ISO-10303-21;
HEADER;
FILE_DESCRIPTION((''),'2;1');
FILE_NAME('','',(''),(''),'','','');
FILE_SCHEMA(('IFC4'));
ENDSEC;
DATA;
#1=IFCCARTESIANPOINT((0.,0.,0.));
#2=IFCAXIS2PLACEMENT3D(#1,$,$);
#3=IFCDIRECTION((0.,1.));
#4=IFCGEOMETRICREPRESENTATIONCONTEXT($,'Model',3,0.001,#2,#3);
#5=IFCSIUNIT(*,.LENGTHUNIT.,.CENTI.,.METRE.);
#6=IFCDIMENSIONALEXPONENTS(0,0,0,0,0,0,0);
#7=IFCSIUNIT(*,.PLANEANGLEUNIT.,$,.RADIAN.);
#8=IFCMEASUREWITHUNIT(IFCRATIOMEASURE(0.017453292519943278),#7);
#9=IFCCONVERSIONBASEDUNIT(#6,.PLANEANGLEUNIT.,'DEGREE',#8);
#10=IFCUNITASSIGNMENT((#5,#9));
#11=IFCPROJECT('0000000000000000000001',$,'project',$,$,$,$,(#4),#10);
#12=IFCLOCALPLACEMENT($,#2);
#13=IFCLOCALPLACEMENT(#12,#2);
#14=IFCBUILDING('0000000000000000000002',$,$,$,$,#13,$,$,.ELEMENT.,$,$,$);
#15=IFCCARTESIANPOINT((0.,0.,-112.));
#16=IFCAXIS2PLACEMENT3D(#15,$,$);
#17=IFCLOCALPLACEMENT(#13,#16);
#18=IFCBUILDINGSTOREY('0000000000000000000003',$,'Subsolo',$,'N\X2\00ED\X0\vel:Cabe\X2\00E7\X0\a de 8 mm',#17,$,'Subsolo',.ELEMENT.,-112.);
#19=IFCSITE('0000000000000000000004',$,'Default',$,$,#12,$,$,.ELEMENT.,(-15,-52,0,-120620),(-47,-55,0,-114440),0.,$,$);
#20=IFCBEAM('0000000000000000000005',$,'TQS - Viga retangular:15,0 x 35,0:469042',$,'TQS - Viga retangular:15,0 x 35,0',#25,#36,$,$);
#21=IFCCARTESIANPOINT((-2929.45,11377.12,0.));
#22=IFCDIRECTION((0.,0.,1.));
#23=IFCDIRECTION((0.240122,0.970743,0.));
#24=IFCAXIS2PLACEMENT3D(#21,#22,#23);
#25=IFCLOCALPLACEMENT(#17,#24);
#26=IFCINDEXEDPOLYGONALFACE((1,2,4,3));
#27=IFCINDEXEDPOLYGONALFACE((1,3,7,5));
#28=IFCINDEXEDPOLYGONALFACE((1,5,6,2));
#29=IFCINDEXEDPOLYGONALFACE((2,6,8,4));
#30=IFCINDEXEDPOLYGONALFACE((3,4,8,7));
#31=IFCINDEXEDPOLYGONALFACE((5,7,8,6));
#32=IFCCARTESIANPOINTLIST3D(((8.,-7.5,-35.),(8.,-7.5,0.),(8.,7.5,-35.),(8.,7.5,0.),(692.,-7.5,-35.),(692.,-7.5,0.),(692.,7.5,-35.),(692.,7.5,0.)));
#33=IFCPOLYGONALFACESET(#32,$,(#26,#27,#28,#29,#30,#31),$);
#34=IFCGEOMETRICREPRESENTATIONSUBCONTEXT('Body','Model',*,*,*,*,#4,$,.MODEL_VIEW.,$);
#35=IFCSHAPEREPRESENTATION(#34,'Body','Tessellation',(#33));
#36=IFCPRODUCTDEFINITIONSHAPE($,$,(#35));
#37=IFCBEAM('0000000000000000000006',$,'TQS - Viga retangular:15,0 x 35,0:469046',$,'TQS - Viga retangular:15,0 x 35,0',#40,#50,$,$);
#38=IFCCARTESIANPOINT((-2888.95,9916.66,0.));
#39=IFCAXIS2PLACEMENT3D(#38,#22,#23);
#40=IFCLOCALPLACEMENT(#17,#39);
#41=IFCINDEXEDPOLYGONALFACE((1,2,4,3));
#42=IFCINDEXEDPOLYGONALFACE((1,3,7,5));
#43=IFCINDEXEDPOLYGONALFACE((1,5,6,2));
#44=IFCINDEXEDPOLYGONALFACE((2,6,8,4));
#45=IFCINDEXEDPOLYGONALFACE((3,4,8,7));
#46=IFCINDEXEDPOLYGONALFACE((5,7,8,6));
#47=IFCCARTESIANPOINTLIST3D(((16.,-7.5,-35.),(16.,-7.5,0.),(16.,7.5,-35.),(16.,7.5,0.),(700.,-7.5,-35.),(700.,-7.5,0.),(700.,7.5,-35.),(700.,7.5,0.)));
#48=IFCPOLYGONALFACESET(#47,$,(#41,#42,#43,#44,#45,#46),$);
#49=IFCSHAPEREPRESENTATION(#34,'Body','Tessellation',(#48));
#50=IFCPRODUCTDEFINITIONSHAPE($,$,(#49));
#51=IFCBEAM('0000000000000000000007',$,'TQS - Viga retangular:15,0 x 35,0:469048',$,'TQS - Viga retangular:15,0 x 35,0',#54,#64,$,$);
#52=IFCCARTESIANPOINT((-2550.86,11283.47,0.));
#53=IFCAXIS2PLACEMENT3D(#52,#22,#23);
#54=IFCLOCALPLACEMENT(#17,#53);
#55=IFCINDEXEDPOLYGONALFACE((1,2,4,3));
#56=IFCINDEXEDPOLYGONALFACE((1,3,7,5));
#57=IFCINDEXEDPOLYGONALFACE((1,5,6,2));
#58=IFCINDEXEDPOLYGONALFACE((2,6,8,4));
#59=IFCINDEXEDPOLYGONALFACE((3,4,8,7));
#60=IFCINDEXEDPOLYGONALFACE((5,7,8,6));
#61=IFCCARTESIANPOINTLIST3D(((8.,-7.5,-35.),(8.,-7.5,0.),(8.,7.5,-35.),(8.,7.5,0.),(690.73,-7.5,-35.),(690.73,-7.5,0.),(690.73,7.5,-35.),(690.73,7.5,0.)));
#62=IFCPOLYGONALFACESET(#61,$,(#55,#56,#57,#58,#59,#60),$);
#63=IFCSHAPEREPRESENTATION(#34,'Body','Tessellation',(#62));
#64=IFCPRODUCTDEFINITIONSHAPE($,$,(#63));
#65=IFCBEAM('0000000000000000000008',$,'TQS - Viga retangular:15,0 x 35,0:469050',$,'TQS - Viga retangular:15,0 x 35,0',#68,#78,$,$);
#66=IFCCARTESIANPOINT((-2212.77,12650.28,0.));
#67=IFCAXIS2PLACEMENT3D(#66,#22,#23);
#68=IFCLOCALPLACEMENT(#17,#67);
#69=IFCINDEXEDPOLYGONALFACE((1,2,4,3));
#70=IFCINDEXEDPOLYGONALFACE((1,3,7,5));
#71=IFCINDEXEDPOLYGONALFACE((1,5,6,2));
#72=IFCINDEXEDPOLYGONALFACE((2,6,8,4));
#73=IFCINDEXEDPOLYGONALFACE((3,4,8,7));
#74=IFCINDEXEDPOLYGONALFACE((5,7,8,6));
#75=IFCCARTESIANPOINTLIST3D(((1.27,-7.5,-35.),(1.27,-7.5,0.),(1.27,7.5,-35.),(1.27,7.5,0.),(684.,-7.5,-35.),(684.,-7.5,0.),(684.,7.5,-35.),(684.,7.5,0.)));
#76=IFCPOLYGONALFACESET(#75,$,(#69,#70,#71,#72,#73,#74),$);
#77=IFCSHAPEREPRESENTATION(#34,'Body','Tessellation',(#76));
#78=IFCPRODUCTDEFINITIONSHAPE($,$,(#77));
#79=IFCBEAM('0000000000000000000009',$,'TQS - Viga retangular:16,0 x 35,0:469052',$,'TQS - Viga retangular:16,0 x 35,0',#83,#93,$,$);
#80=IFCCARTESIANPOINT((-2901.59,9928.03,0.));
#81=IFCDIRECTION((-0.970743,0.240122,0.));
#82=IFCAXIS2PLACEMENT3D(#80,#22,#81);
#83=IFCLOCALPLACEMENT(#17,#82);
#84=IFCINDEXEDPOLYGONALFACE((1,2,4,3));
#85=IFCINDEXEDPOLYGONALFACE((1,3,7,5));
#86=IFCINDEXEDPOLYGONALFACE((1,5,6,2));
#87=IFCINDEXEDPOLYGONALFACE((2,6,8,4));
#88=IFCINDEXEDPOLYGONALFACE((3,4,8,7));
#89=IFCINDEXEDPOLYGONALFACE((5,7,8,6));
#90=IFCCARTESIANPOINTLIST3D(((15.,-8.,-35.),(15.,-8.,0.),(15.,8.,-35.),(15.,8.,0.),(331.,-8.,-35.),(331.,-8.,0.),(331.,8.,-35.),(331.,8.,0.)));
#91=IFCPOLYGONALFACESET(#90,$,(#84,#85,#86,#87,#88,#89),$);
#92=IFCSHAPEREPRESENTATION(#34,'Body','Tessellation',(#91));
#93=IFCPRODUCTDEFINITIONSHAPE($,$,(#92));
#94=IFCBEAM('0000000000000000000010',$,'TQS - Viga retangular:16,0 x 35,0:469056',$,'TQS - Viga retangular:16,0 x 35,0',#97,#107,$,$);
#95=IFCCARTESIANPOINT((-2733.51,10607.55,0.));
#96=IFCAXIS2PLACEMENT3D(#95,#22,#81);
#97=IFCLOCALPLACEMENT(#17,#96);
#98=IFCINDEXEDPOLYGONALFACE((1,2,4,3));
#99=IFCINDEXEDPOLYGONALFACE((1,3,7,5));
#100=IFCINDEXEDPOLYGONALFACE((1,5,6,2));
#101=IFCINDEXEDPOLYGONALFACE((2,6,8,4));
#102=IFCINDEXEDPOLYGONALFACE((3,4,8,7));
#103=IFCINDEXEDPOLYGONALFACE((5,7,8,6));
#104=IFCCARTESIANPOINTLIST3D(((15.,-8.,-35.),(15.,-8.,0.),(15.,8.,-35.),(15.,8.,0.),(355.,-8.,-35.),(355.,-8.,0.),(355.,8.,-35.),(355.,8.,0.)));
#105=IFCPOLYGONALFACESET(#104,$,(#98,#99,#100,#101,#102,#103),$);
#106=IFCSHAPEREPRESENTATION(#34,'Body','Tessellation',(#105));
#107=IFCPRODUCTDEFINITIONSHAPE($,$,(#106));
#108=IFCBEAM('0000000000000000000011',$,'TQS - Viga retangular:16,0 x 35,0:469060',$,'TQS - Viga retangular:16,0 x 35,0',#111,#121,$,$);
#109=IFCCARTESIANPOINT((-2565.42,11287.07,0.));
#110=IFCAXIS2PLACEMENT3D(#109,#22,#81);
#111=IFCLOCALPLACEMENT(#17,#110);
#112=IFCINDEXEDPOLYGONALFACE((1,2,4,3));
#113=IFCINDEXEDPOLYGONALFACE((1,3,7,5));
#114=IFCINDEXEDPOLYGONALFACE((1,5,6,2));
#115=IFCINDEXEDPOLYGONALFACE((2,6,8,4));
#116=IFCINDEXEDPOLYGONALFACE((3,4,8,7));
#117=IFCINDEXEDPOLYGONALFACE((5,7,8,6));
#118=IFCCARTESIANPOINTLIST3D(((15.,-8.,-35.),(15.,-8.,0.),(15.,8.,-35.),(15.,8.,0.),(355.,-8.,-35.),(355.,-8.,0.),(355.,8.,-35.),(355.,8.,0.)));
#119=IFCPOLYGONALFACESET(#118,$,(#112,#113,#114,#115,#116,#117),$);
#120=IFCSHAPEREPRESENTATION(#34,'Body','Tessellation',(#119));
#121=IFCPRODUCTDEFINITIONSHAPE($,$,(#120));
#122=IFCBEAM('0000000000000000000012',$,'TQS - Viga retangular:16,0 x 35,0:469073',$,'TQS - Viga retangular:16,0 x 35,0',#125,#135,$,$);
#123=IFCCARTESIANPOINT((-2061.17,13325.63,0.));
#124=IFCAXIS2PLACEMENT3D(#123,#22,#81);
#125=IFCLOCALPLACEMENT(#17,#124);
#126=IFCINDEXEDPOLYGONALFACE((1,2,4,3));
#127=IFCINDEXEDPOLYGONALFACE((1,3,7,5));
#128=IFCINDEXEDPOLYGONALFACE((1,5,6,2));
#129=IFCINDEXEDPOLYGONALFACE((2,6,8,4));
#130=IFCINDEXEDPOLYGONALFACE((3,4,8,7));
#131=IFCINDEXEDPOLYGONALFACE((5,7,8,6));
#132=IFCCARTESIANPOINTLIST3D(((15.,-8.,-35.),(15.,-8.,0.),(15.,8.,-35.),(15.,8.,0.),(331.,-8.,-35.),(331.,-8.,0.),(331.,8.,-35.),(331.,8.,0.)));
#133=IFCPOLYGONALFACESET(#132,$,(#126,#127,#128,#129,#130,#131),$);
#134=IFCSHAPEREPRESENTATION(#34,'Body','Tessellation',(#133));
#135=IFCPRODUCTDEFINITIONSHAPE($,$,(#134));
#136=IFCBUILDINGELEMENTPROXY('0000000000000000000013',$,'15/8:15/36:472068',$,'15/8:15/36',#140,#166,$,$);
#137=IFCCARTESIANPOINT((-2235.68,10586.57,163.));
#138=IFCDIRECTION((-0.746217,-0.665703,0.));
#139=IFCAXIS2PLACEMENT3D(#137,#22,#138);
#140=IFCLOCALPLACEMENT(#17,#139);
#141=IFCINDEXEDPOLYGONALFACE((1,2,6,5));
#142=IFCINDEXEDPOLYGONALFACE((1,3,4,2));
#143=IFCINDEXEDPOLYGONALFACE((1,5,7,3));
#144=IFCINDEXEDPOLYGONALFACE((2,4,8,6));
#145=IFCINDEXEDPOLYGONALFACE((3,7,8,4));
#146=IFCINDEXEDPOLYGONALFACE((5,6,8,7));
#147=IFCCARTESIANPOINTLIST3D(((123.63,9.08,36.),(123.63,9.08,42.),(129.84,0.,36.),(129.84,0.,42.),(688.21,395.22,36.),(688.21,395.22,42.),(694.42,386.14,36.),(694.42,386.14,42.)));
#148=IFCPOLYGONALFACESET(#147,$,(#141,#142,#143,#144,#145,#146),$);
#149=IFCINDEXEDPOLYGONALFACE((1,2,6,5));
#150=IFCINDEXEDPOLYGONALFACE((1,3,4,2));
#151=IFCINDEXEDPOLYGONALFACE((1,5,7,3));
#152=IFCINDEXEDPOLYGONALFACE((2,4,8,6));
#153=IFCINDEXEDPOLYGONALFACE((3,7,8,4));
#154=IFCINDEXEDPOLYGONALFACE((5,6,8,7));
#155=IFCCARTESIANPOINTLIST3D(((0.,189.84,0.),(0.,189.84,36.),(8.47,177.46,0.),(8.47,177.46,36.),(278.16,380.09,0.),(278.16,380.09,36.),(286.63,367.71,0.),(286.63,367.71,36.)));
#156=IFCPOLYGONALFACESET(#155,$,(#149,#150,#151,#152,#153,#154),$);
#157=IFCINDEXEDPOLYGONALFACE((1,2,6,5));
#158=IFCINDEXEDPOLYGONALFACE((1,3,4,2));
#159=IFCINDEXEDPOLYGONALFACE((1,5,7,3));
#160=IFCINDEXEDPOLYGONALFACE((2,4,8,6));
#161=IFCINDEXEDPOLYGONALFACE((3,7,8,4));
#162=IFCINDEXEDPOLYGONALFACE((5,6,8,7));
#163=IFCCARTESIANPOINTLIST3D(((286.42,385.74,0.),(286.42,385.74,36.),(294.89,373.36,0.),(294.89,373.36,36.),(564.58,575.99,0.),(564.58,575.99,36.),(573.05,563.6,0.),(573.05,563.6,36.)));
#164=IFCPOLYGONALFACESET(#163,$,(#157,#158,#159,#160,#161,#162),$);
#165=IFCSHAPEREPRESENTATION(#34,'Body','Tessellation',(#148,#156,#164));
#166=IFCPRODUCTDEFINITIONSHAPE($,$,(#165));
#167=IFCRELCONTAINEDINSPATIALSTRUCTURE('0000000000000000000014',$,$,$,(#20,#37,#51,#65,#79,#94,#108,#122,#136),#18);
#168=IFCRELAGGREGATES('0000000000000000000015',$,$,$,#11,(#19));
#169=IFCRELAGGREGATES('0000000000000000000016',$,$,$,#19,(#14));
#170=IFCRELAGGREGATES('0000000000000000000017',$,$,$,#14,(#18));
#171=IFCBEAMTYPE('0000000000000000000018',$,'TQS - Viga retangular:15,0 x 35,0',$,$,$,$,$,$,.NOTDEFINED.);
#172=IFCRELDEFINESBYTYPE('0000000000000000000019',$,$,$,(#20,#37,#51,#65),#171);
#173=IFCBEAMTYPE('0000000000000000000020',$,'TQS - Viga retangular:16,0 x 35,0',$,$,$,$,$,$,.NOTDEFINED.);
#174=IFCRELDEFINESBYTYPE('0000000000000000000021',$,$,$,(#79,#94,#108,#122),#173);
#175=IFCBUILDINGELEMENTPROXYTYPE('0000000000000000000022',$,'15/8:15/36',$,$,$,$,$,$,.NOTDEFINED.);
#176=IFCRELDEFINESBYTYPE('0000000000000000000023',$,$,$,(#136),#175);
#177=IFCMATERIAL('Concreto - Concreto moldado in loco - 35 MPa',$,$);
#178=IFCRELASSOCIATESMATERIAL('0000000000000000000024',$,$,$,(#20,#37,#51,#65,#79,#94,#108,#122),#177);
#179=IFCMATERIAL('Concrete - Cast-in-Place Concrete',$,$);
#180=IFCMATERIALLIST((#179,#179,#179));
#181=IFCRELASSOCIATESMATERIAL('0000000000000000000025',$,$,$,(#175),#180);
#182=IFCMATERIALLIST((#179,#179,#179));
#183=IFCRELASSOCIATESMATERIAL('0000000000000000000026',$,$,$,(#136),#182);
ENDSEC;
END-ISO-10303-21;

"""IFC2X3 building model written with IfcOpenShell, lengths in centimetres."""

from ifc_helpers import new_model, entity, si_unit, converted_unit, direction, frame, frame_2d, origin, place, context, subcontext, project, spatial, rectangle, extrude, source, transform, mapped, material, material_list, type_object, type_shapes, element, save


model = new_model("IFC2X3")

# Units and contexts
model_context = context("Model", 3, precision=0.001, world=origin(), true_north=direction((0.0, 1.0)))
body_context = subcontext(model_context, "Body", "Model", "MODEL_VIEW")
ifc_project = project(units=[si_unit("LENGTHUNIT", "METRE", prefix="CENTI"), converted_unit("PLANEANGLEUNIT", "DEGREE", entity("IfcRatioMeasure", 0.017453292519943278), si_unit("PLANEANGLEUNIT", "RADIAN"), dimensions=[0, 0, 0, 0, 0, 0, 0])], contexts=[model_context])

# Site, building, storey
site_placement = place(None, origin())
site = spatial("IfcSite", under=ifc_project, at=site_placement, Name="Default", CompositionType="ELEMENT", RefLatitude=(-15, -52, 0, -120620), RefLongitude=(-47, -55, 0, -114440), RefElevation=0.0)
building_placement = place(site_placement, origin())
building = spatial("IfcBuilding", under=site, at=building_placement, CompositionType="ELEMENT")
storey_placement = place(building_placement, frame((0.0, 0.0, -112.0)))
storey = spatial("IfcBuildingStorey", under=building, at=storey_placement, Name="Subsolo", ObjectType="Nível:Cabeça de 8 mm", LongName="Subsolo", CompositionType="ELEMENT", Elevation=-112.0)

# Shared definitions
ifc_material_1 = material(Name="Concreto - Concreto moldado in loco - 35 MPa")

# Beams
beam_type_1 = type_object("IfcBeamType", Name="TQS - Viga retangular:15,0 x 35,0", PredefinedType="NOTDEFINED")
beam_1_placement = place(storey_placement, frame((-2929.45, 11377.12, 0.0), z_axis=(0.0, 0.0, 1.0), x_axis=(0.240122, 0.970743, 0.0)))
element("IfcBeam", 1, at=beam_1_placement, inside=storey, type_object=beam_type_1, material=ifc_material_1, Name="TQS - Viga retangular:15,0 x 35,0:469042", ObjectType="TQS - Viga retangular:15,0 x 35,0", context=body_context, shape_type="SweptSolid", body=[
    extrude(rectangle(XDim=35.0, YDim=15.0, at=frame_2d((0.0, 0.0), x_axis=(1.0, 0.0))), frame((8.0, 0.0, -17.5), z_axis=(1.0, 0.0, 0.0), x_axis=(0.0, 0.0, -1.0)), (0.0, 0.0, 1.0), 684.0),
])
beam_2_placement = place(storey_placement, frame((-2888.95, 9916.66, 0.0), z_axis=(0.0, 0.0, 1.0), x_axis=(0.240122, 0.970743, 0.0)))
element("IfcBeam", 2, at=beam_2_placement, inside=storey, type_object=beam_type_1, material=ifc_material_1, Name="TQS - Viga retangular:15,0 x 35,0:469046", ObjectType="TQS - Viga retangular:15,0 x 35,0", context=body_context, shape_type="SweptSolid", body=[
    extrude(rectangle(XDim=35.0, YDim=15.0, at=frame_2d((0.0, 0.0), x_axis=(1.0, 0.0))), frame((16.0, 0.0, -17.5), z_axis=(1.0, 0.0, 0.0), x_axis=(0.0, 0.0, -1.0)), (0.0, 0.0, 1.0), 684.0),
])
beam_3_placement = place(storey_placement, frame((-2550.86, 11283.47, 0.0), z_axis=(0.0, 0.0, 1.0), x_axis=(0.240122, 0.970743, 0.0)))
element("IfcBeam", 3, at=beam_3_placement, inside=storey, type_object=beam_type_1, material=ifc_material_1, Name="TQS - Viga retangular:15,0 x 35,0:469048", ObjectType="TQS - Viga retangular:15,0 x 35,0", context=body_context, shape_type="SweptSolid", body=[
    extrude(rectangle(XDim=35.0, YDim=15.0, at=frame_2d((0.0, 0.0), x_axis=(1.0, 0.0))), frame((8.0, 0.0, -17.5), z_axis=(1.0, 0.0, 0.0), x_axis=(0.0, 0.0, -1.0)), (0.0, 0.0, 1.0), 682.73),
])
beam_4_placement = place(storey_placement, frame((-2212.77, 12650.28, 0.0), z_axis=(0.0, 0.0, 1.0), x_axis=(0.240122, 0.970743, 0.0)))
element("IfcBeam", 4, at=beam_4_placement, inside=storey, type_object=beam_type_1, material=ifc_material_1, Name="TQS - Viga retangular:15,0 x 35,0:469050", ObjectType="TQS - Viga retangular:15,0 x 35,0", context=body_context, shape_type="SweptSolid", body=[
    extrude(rectangle(XDim=35.0, YDim=15.0, at=frame_2d((0.0, 0.0), x_axis=(1.0, 0.0))), frame((1.27, 0.0, -17.5), z_axis=(1.0, 0.0, 0.0), x_axis=(0.0, 0.0, -1.0)), (0.0, 0.0, 1.0), 682.73),
])
beam_type_2 = type_object("IfcBeamType", Name="TQS - Viga retangular:16,0 x 35,0", PredefinedType="NOTDEFINED")
beam_5_placement = place(storey_placement, frame((-2901.59, 9928.03, 0.0), z_axis=(0.0, 0.0, 1.0), x_axis=(-0.970743, 0.240122, 0.0)))
element("IfcBeam", 5, at=beam_5_placement, inside=storey, type_object=beam_type_2, material=ifc_material_1, Name="TQS - Viga retangular:16,0 x 35,0:469052", ObjectType="TQS - Viga retangular:16,0 x 35,0", context=body_context, shape_type="SweptSolid", body=[
    extrude(rectangle(XDim=35.0, YDim=16.0, at=frame_2d((0.0, 0.0), x_axis=(1.0, 0.0))), frame((15.0, 0.0, -17.5), z_axis=(1.0, 0.0, 0.0), x_axis=(0.0, 0.0, -1.0)), (0.0, 0.0, 1.0), 316.0),
])
beam_6_placement = place(storey_placement, frame((-2733.51, 10607.55, 0.0), z_axis=(0.0, 0.0, 1.0), x_axis=(-0.970743, 0.240122, 0.0)))
element("IfcBeam", 6, at=beam_6_placement, inside=storey, type_object=beam_type_2, material=ifc_material_1, Name="TQS - Viga retangular:16,0 x 35,0:469056", ObjectType="TQS - Viga retangular:16,0 x 35,0", context=body_context, shape_type="SweptSolid", body=[
    extrude(rectangle(XDim=35.0, YDim=16.0, at=frame_2d((0.0, 0.0), x_axis=(1.0, 0.0))), frame((15.0, 0.0, -17.5), z_axis=(1.0, 0.0, 0.0), x_axis=(0.0, 0.0, -1.0)), (0.0, 0.0, 1.0), 340.0),
])
beam_7_placement = place(storey_placement, frame((-2565.42, 11287.07, 0.0), z_axis=(0.0, 0.0, 1.0), x_axis=(-0.970743, 0.240122, 0.0)))
element("IfcBeam", 7, at=beam_7_placement, inside=storey, type_object=beam_type_2, material=ifc_material_1, Name="TQS - Viga retangular:16,0 x 35,0:469060", ObjectType="TQS - Viga retangular:16,0 x 35,0", context=body_context, shape_type="SweptSolid", body=[
    extrude(rectangle(XDim=35.0, YDim=16.0, at=frame_2d((0.0, 0.0), x_axis=(1.0, 0.0))), frame((15.0, 0.0, -17.5), z_axis=(1.0, 0.0, 0.0), x_axis=(0.0, 0.0, -1.0)), (0.0, 0.0, 1.0), 340.0),
])
beam_8_placement = place(storey_placement, frame((-2061.17, 13325.63, 0.0), z_axis=(0.0, 0.0, 1.0), x_axis=(-0.970743, 0.240122, 0.0)))
element("IfcBeam", 8, at=beam_8_placement, inside=storey, type_object=beam_type_2, material=ifc_material_1, Name="TQS - Viga retangular:16,0 x 35,0:469073", ObjectType="TQS - Viga retangular:16,0 x 35,0", context=body_context, shape_type="SweptSolid", body=[
    extrude(rectangle(XDim=35.0, YDim=16.0, at=frame_2d((0.0, 0.0), x_axis=(1.0, 0.0))), frame((15.0, 0.0, -17.5), z_axis=(1.0, 0.0, 0.0), x_axis=(0.0, 0.0, -1.0)), (0.0, 0.0, 1.0), 316.0),
])

# Building element proxy
ifc_material_2 = material(Name="Concrete - Cast-in-Place Concrete")
ifc_material_list_1 = material_list([ifc_material_2, ifc_material_2, ifc_material_2])
ifc_material_list_2 = material_list([ifc_material_2, ifc_material_2, ifc_material_2])
building_element_proxy_type_1 = type_object("IfcBuildingElementProxyType", Name="15/8:15/36", PredefinedType="NOTDEFINED", material=ifc_material_list_2)
shared_shape_1 = source(origin(), body_context, "Body", "SweptSolid", [
    extrude(rectangle(XDim=11.0, YDim=684.0, at=frame_2d((0.0, 0.0), x_axis=(1.0, 0.0))), frame((409.03, 197.61, 36.0), z_axis=(0.0, 0.0, 1.0), x_axis=(-0.564535, 0.825409, 0.0)), (0.0, 0.0, 1.0), 6.0),
    extrude(rectangle(XDim=337.0, YDim=15.0, at=frame_2d((0.0, 0.0), x_axis=(1.0, 0.0))), frame((143.32, 278.78, 0.0), z_axis=(0.0, 0.0, 1.0), x_axis=(0.825409, 0.564535, 0.0)), (0.0, 0.0, 1.0), 36.0),
    extrude(rectangle(XDim=337.0, YDim=15.0, at=frame_2d((0.0, 0.0), x_axis=(1.0, 0.0))), frame((429.73, 474.67, 0.0), z_axis=(0.0, 0.0, 1.0), x_axis=(0.825409, 0.564535, 0.0)), (0.0, 0.0, 1.0), 36.0),
])
type_shapes(building_element_proxy_type_1, [shared_shape_1])
proxy_1_placement = place(storey_placement, frame((-2235.68, 10586.57, 163.0), z_axis=(0.0, 0.0, 1.0), x_axis=(-0.746217, -0.665703, 0.0)))
element("IfcBuildingElementProxy", 9, at=proxy_1_placement, inside=storey, type_object=building_element_proxy_type_1, material=ifc_material_list_1, Name="15/8:15/36:472068", ObjectType="15/8:15/36", context=body_context, shape_type="MappedRepresentation", body=[
    mapped(shared_shape_1, transform((0.0, 0.0, 0.0), scale=1.0)),
])

save(model, "model.ifc")
